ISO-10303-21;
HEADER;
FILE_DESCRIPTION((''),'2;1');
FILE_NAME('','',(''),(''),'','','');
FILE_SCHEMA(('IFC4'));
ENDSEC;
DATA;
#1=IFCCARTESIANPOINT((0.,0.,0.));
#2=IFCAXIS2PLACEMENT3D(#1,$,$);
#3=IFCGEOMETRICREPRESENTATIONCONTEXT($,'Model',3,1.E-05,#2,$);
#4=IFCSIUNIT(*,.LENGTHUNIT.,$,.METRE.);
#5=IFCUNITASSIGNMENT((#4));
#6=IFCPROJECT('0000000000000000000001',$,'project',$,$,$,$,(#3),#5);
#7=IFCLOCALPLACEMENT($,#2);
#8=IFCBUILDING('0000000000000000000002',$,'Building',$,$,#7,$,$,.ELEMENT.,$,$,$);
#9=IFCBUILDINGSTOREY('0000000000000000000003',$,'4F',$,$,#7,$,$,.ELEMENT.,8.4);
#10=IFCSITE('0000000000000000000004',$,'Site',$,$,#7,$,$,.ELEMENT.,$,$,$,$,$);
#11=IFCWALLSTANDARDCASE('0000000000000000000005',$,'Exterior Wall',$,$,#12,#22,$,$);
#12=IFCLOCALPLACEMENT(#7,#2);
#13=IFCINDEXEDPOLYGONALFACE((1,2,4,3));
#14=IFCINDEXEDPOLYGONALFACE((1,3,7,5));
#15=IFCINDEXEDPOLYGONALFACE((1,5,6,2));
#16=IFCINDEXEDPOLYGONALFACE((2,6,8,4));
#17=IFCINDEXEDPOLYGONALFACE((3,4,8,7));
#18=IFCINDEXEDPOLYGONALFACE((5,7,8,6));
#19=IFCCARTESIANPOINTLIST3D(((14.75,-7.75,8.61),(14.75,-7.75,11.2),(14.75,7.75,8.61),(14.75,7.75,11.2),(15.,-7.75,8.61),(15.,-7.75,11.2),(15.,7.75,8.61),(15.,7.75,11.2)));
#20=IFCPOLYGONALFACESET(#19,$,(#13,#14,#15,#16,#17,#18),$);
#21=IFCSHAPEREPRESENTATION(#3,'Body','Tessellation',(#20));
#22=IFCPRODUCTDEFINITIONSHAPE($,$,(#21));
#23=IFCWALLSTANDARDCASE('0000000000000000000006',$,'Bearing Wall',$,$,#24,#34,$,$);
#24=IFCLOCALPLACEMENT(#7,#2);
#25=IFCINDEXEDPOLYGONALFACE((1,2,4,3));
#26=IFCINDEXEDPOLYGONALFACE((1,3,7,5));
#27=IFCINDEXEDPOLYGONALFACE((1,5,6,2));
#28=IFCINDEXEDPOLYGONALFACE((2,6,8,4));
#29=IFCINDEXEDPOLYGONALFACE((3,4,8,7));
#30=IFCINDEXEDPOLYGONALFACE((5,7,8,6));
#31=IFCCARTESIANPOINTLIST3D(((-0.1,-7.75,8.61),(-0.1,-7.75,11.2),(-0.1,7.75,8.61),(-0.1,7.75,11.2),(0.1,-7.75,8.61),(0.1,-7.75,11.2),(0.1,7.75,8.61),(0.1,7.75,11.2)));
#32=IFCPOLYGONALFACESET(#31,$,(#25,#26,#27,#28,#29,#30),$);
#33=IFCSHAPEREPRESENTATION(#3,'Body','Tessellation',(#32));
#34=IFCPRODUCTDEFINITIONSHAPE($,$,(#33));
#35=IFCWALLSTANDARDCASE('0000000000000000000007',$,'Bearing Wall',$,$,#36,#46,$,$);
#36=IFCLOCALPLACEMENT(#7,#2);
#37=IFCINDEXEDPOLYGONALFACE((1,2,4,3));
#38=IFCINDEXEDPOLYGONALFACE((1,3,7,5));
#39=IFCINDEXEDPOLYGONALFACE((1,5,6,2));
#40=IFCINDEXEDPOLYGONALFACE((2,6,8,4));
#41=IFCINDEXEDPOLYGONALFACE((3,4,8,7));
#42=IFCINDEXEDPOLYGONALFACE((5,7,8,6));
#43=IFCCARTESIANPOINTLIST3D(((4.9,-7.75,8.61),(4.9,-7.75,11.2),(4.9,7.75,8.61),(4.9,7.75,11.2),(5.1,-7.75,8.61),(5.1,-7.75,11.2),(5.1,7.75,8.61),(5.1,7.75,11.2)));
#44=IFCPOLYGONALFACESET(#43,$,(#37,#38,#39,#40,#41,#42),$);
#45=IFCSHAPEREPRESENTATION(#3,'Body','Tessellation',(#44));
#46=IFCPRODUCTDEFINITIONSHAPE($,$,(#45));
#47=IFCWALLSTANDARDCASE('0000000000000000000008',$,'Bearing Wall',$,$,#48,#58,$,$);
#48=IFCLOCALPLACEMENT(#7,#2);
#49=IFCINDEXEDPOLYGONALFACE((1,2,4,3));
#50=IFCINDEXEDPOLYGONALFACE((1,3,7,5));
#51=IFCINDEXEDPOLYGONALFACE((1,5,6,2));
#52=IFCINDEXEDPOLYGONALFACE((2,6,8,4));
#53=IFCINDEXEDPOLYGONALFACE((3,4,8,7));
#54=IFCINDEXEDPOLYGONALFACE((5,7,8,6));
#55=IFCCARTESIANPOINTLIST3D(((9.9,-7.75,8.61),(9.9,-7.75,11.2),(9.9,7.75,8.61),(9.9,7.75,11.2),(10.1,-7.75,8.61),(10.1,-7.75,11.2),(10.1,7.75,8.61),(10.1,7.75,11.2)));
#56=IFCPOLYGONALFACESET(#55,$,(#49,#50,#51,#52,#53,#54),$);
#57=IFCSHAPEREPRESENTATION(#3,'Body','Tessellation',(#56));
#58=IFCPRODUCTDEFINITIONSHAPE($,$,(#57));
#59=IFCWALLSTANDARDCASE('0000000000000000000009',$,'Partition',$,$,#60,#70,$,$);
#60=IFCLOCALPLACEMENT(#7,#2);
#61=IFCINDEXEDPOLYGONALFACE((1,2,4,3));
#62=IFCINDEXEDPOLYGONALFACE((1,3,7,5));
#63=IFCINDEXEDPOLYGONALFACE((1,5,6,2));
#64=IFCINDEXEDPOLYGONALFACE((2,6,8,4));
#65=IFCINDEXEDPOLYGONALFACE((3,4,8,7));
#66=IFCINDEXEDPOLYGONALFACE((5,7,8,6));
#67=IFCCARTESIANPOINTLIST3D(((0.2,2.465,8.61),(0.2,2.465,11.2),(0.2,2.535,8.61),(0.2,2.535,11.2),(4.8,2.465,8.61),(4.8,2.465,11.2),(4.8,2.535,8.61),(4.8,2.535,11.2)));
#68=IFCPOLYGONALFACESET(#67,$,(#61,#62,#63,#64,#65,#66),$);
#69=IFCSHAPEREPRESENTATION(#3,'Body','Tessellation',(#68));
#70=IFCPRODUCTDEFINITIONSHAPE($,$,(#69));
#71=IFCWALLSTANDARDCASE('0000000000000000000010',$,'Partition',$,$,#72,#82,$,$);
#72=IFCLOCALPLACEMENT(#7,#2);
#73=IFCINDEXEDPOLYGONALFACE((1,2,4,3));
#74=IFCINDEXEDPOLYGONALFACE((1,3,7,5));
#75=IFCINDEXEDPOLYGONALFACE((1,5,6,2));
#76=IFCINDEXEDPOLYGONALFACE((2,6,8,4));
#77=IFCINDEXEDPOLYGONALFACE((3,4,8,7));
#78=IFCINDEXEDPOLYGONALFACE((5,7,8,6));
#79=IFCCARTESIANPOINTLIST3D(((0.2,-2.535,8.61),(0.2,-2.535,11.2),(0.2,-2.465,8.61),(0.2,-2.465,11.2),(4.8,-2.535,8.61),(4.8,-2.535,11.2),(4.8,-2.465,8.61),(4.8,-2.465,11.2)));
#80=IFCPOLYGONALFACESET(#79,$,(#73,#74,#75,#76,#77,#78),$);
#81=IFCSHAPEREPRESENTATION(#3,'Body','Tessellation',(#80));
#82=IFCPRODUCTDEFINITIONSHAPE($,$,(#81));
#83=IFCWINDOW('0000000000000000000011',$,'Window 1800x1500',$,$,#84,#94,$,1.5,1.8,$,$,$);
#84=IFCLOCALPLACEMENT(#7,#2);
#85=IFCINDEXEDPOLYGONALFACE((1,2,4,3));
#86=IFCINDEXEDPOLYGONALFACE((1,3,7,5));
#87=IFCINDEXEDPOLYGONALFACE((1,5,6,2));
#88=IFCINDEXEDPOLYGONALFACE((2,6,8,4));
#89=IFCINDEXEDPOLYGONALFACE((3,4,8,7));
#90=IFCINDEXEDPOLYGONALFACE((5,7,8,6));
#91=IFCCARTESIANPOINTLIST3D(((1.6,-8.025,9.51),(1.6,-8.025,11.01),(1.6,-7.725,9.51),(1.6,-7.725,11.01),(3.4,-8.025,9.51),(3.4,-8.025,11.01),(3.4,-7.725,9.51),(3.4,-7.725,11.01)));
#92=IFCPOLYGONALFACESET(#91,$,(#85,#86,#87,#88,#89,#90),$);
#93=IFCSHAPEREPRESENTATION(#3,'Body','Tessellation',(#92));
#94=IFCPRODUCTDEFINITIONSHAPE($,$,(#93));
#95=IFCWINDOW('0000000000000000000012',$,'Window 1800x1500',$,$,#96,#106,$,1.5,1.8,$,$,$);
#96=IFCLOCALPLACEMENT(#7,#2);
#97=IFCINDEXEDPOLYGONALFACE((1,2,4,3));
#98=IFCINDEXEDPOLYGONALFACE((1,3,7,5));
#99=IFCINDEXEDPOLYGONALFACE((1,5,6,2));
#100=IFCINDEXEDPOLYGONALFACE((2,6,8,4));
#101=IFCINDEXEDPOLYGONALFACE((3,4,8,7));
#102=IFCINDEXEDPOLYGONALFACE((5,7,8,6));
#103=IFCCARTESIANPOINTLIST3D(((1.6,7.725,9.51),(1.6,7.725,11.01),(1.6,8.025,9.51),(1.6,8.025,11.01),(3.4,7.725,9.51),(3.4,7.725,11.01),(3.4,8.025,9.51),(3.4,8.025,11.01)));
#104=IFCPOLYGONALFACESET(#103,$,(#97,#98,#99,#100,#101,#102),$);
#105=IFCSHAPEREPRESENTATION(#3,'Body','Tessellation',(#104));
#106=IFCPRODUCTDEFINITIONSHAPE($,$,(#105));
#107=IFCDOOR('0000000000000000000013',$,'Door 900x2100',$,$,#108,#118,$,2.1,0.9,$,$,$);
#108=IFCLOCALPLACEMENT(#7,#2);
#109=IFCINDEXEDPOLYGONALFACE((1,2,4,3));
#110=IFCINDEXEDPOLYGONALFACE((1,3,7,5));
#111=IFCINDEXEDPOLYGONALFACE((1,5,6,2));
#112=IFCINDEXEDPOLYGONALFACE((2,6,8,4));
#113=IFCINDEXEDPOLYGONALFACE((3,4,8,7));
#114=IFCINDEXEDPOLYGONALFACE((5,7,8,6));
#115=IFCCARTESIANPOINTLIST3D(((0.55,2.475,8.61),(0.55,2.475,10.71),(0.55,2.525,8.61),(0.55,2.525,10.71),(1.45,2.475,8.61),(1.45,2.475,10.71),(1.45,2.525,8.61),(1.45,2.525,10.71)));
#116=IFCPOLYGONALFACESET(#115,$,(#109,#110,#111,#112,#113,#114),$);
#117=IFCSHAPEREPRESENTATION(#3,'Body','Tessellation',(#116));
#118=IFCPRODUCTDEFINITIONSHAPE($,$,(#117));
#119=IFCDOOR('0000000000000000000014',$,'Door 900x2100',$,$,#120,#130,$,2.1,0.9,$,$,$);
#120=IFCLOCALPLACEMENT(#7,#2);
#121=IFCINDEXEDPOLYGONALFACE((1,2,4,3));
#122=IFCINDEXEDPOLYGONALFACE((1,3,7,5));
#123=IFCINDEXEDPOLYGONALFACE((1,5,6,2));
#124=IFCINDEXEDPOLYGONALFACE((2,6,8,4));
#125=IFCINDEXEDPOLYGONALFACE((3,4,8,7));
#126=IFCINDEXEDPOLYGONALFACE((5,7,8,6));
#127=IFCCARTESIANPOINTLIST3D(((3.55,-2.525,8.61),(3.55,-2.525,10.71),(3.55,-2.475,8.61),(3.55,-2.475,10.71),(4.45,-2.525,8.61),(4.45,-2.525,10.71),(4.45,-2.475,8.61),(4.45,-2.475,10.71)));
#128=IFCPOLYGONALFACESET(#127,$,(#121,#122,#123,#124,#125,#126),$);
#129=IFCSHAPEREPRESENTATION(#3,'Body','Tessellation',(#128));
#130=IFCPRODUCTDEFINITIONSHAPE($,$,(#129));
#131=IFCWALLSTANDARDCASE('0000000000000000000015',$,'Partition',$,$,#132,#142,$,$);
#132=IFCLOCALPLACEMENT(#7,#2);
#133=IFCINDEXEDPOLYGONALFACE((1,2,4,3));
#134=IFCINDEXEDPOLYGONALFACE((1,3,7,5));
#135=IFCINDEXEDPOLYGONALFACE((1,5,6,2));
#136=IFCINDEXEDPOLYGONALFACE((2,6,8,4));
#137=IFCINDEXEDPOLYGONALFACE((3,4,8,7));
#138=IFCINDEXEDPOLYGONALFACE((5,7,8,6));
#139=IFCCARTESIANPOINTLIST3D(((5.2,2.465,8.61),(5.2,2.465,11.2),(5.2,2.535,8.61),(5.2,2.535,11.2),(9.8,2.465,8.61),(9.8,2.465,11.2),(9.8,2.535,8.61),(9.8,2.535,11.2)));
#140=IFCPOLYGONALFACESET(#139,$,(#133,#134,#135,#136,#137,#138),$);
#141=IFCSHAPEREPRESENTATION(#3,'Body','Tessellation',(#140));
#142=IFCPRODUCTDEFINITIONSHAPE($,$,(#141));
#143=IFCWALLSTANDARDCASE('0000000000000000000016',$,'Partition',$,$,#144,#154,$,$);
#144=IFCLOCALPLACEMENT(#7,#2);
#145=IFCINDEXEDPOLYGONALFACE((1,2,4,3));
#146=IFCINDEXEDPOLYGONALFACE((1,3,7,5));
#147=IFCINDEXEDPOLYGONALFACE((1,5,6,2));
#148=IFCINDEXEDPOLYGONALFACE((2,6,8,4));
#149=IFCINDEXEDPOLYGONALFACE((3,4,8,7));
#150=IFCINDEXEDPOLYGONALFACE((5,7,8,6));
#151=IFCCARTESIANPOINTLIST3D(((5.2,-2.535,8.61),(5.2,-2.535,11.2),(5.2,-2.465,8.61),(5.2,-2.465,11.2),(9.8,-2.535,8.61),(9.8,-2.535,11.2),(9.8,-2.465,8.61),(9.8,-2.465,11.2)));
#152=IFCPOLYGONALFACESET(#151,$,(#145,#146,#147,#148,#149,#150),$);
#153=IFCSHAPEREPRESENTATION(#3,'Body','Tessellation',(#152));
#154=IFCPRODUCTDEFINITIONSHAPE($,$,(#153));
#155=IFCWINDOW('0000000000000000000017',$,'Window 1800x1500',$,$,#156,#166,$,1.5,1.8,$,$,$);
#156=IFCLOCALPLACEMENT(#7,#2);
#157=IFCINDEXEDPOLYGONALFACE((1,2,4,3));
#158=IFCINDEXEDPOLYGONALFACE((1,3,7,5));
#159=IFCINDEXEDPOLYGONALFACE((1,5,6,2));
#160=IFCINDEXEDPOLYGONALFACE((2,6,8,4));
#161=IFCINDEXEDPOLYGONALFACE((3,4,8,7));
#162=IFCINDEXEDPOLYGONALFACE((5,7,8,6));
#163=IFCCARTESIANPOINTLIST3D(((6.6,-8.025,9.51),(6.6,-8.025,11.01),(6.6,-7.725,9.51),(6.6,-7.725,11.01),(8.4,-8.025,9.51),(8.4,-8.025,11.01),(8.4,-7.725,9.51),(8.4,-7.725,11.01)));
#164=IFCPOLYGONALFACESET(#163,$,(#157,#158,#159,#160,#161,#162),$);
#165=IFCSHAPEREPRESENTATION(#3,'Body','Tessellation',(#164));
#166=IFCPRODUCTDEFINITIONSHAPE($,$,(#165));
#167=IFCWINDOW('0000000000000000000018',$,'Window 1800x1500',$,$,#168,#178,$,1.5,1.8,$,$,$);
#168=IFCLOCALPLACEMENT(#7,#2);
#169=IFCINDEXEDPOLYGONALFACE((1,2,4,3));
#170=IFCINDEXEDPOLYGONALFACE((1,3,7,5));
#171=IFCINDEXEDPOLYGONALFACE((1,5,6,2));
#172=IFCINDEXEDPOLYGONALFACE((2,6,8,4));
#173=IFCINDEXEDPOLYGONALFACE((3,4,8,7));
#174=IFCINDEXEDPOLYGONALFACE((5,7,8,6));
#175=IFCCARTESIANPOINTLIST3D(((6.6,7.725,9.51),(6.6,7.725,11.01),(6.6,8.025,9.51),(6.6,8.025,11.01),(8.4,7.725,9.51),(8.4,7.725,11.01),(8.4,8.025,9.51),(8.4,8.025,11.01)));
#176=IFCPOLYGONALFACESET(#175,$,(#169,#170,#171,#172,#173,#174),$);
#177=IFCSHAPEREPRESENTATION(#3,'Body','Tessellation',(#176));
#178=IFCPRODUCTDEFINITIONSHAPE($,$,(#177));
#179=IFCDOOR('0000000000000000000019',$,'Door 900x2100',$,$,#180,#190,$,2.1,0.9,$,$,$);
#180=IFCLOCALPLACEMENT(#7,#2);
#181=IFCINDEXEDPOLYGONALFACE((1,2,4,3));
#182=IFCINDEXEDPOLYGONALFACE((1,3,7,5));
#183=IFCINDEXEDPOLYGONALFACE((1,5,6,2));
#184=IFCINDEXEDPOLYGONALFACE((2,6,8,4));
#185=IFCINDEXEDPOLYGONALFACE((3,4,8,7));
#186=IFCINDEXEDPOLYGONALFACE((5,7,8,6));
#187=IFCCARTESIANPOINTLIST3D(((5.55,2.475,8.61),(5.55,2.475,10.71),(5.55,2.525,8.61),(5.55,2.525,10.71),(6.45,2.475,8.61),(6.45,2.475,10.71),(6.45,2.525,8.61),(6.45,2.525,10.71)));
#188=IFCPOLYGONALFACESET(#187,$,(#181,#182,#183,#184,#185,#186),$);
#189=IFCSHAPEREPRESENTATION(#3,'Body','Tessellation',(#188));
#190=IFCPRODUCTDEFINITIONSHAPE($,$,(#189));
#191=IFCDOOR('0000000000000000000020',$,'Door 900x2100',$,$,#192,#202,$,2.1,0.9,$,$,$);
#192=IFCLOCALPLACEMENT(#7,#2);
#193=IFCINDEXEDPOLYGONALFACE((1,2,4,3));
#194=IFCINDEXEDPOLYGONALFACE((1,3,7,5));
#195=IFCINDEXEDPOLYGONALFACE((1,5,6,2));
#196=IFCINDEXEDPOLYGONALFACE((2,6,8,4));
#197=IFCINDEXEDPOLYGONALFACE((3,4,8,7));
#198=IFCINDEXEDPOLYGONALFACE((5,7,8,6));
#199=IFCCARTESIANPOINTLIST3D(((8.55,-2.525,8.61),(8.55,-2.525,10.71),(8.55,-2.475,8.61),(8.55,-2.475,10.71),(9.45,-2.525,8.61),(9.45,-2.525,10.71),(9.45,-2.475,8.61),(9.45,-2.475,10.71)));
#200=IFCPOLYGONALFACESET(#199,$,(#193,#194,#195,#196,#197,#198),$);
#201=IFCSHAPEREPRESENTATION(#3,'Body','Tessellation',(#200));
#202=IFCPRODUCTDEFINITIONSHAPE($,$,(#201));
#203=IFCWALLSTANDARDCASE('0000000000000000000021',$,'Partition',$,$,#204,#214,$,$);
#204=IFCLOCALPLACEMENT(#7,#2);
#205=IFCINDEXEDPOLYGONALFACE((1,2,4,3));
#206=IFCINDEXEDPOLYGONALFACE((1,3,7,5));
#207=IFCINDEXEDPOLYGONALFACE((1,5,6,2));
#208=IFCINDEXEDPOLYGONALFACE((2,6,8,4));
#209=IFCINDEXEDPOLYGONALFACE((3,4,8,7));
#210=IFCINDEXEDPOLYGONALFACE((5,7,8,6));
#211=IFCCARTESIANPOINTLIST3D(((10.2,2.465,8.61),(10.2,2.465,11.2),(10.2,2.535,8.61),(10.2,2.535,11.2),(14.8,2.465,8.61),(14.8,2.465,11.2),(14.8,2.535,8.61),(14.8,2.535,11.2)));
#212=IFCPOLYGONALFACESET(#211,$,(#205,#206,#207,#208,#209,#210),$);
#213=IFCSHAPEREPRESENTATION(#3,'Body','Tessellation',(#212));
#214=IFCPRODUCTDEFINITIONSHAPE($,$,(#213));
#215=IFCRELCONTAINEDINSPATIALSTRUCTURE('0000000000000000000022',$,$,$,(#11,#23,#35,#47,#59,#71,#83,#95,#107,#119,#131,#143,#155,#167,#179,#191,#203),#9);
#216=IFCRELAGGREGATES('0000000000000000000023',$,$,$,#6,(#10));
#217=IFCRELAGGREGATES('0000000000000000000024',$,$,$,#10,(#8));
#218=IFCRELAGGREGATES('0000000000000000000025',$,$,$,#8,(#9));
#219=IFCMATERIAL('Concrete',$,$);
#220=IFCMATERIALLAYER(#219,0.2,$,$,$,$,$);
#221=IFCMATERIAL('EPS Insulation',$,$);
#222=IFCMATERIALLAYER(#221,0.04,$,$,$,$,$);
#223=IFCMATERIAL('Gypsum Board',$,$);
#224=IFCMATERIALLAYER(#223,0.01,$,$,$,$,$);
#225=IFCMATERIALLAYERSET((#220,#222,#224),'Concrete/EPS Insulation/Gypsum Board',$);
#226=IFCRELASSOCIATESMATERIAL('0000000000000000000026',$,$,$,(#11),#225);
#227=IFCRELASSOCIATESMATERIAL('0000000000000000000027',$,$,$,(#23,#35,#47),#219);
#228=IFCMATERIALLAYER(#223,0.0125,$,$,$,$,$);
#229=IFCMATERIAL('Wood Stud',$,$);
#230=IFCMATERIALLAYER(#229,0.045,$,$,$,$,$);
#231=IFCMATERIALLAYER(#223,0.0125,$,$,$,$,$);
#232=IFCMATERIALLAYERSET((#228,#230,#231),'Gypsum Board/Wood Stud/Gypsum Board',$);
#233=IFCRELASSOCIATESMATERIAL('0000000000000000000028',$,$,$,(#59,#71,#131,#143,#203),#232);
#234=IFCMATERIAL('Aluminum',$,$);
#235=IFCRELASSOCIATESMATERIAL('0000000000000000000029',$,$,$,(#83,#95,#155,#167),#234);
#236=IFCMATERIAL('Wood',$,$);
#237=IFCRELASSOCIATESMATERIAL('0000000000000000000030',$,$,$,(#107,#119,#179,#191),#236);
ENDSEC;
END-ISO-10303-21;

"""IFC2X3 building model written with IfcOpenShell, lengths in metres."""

from ifc_helpers import new_model, si_unit, frame, origin, origin_2d, place, context, project, spatial, rectangle, extrude, material, layer, layer_set, layer_usage, element, save


model = new_model("IFC2X3")

# Units and contexts
model_context = context("Model", 3, precision=1e-05, world=origin())
ifc_project = project(units=[si_unit("LENGTHUNIT", "METRE")], contexts=[model_context])

# Site, building, storey
placement = place(None, origin())
site = spatial("IfcSite", under=ifc_project, at=placement, Name="Site", CompositionType="ELEMENT")
building = spatial("IfcBuilding", under=site, at=placement, Name="Building", CompositionType="ELEMENT")
storey = spatial("IfcBuildingStorey", under=building, at=placement, Name="4F", CompositionType="ELEMENT", Elevation=8.4)

# Walls
ifc_material_1 = material(Name="Concrete")
ifc_layer_1 = layer(ifc_material_1, 0.2)
ifc_material_2 = material(Name="EPS Insulation")
ifc_layer_2 = layer(ifc_material_2, 0.04)
ifc_material_3 = material(Name="Gypsum Board")
ifc_layer_3 = layer(ifc_material_3, 0.01)
ifc_layer_set_1 = layer_set([ifc_layer_1, ifc_layer_2, ifc_layer_3], Name="Concrete/EPS Insulation/Gypsum Board")
ifc_layer_usage_1 = layer_usage(ifc_layer_set_1, "AXIS2", "POSITIVE", 0.0)
wall_placement = place(None, frame((14.875, 0.0, 8.61)))
element("IfcWallStandardCase", 1, at=wall_placement, inside=storey, material=ifc_layer_usage_1, Name="Exterior Wall", context=model_context, shape_type="SweptSolid", body=[
    extrude(rectangle(XDim=0.25, YDim=15.5, at=origin_2d()), origin(), (0.0, 0.0, 1.0), 2.59),
])
for number, where, name in (
    (2, (0.0, 0.0, 8.61), "Bearing Wall"),
    (3, (5.0, 0.0, 8.61), "Bearing Wall"),
    (4, (10.0, 0.0, 8.61), "Bearing Wall"),
):
    element("IfcWallStandardCase", number, at=place(None, frame(where)), inside=storey, material=ifc_material_1, Name=name, context=model_context, shape_type="SweptSolid", body=[
        extrude(rectangle(XDim=0.2, YDim=15.5, at=origin_2d()), origin(), (0.0, 0.0, 1.0), 2.59),
    ])
ifc_layer_4 = layer(ifc_material_3, 0.0125)
ifc_material_4 = material(Name="Wood Stud")
ifc_layer_5 = layer(ifc_material_4, 0.045)
ifc_layer_6 = layer(ifc_material_3, 0.0125)
ifc_layer_set_2 = layer_set([ifc_layer_4, ifc_layer_5, ifc_layer_6], Name="Gypsum Board/Wood Stud/Gypsum Board")
ifc_layer_usage_2 = layer_usage(ifc_layer_set_2, "AXIS2", "POSITIVE", 0.0)
for number, where, name in (
    (5, (2.5, 2.5, 8.61), "Partition"),
    (6, (2.5, -2.5, 8.61), "Partition"),
):
    element("IfcWallStandardCase", number, at=place(None, frame(where)), inside=storey, material=ifc_layer_usage_2, Name=name, context=model_context, shape_type="SweptSolid", body=[
        extrude(rectangle(XDim=4.6, YDim=0.07, at=origin_2d()), origin(), (0.0, 0.0, 1.0), 2.59),
    ])

# Windows
ifc_material_5 = material(Name="Aluminum")
for number, where, name in (
    (7, (2.5, -7.875, 9.51), "Window 1800x1500"),
    (8, (2.5, 7.875, 9.51), "Window 1800x1500"),
):
    element("IfcWindow", number, at=place(None, frame(where)), inside=storey, material=ifc_material_5, Name=name, OverallHeight=1.5, OverallWidth=1.8, context=model_context, shape_type="SweptSolid", body=[
        extrude(rectangle(XDim=1.8, YDim=0.3, at=origin_2d()), origin(), (0.0, 0.0, 1.0), 1.5),
    ])

# Doors
ifc_material_6 = material(Name="Wood")
for number, where, name in (
    (9, (1.0, 2.5, 8.61), "Door 900x2100"),
    (10, (4.0, -2.5, 8.61), "Door 900x2100"),
):
    element("IfcDoor", number, at=place(None, frame(where)), inside=storey, material=ifc_material_6, Name=name, OverallHeight=2.1, OverallWidth=0.9, context=model_context, shape_type="SweptSolid", body=[
        extrude(rectangle(XDim=0.9, YDim=0.05, at=origin_2d()), origin(), (0.0, 0.0, 1.0), 2.1),
    ])

# Walls
for number, where, name in (
    (11, (7.5, 2.5, 8.61), "Partition"),
    (12, (7.5, -2.5, 8.61), "Partition"),
):
    element("IfcWallStandardCase", number, at=place(None, frame(where)), inside=storey, material=ifc_layer_usage_2, Name=name, context=model_context, shape_type="SweptSolid", body=[
        extrude(rectangle(XDim=4.6, YDim=0.07, at=origin_2d()), origin(), (0.0, 0.0, 1.0), 2.59),
    ])

# Windows
for number, where, name in (
    (13, (7.5, -7.875, 9.51), "Window 1800x1500"),
    (14, (7.5, 7.875, 9.51), "Window 1800x1500"),
):
    element("IfcWindow", number, at=place(None, frame(where)), inside=storey, material=ifc_material_5, Name=name, OverallHeight=1.5, OverallWidth=1.8, context=model_context, shape_type="SweptSolid", body=[
        extrude(rectangle(XDim=1.8, YDim=0.3, at=origin_2d()), origin(), (0.0, 0.0, 1.0), 1.5),
    ])

# Doors
for number, where, name in (
    (15, (6.0, 2.5, 8.61), "Door 900x2100"),
    (16, (9.0, -2.5, 8.61), "Door 900x2100"),
):
    element("IfcDoor", number, at=place(None, frame(where)), inside=storey, material=ifc_material_6, Name=name, OverallHeight=2.1, OverallWidth=0.9, context=model_context, shape_type="SweptSolid", body=[
        extrude(rectangle(XDim=0.9, YDim=0.05, at=origin_2d()), origin(), (0.0, 0.0, 1.0), 2.1),
    ])

# Wall
for number, where, name in (
    (17, (12.5, 2.5, 8.61), "Partition"),
):
    element("IfcWallStandardCase", number, at=place(None, frame(where)), inside=storey, material=ifc_layer_usage_2, Name=name, context=model_context, shape_type="SweptSolid", body=[
        extrude(rectangle(XDim=4.6, YDim=0.07, at=origin_2d()), origin(), (0.0, 0.0, 1.0), 2.59),
    ])

save(model, "model.ifc")
